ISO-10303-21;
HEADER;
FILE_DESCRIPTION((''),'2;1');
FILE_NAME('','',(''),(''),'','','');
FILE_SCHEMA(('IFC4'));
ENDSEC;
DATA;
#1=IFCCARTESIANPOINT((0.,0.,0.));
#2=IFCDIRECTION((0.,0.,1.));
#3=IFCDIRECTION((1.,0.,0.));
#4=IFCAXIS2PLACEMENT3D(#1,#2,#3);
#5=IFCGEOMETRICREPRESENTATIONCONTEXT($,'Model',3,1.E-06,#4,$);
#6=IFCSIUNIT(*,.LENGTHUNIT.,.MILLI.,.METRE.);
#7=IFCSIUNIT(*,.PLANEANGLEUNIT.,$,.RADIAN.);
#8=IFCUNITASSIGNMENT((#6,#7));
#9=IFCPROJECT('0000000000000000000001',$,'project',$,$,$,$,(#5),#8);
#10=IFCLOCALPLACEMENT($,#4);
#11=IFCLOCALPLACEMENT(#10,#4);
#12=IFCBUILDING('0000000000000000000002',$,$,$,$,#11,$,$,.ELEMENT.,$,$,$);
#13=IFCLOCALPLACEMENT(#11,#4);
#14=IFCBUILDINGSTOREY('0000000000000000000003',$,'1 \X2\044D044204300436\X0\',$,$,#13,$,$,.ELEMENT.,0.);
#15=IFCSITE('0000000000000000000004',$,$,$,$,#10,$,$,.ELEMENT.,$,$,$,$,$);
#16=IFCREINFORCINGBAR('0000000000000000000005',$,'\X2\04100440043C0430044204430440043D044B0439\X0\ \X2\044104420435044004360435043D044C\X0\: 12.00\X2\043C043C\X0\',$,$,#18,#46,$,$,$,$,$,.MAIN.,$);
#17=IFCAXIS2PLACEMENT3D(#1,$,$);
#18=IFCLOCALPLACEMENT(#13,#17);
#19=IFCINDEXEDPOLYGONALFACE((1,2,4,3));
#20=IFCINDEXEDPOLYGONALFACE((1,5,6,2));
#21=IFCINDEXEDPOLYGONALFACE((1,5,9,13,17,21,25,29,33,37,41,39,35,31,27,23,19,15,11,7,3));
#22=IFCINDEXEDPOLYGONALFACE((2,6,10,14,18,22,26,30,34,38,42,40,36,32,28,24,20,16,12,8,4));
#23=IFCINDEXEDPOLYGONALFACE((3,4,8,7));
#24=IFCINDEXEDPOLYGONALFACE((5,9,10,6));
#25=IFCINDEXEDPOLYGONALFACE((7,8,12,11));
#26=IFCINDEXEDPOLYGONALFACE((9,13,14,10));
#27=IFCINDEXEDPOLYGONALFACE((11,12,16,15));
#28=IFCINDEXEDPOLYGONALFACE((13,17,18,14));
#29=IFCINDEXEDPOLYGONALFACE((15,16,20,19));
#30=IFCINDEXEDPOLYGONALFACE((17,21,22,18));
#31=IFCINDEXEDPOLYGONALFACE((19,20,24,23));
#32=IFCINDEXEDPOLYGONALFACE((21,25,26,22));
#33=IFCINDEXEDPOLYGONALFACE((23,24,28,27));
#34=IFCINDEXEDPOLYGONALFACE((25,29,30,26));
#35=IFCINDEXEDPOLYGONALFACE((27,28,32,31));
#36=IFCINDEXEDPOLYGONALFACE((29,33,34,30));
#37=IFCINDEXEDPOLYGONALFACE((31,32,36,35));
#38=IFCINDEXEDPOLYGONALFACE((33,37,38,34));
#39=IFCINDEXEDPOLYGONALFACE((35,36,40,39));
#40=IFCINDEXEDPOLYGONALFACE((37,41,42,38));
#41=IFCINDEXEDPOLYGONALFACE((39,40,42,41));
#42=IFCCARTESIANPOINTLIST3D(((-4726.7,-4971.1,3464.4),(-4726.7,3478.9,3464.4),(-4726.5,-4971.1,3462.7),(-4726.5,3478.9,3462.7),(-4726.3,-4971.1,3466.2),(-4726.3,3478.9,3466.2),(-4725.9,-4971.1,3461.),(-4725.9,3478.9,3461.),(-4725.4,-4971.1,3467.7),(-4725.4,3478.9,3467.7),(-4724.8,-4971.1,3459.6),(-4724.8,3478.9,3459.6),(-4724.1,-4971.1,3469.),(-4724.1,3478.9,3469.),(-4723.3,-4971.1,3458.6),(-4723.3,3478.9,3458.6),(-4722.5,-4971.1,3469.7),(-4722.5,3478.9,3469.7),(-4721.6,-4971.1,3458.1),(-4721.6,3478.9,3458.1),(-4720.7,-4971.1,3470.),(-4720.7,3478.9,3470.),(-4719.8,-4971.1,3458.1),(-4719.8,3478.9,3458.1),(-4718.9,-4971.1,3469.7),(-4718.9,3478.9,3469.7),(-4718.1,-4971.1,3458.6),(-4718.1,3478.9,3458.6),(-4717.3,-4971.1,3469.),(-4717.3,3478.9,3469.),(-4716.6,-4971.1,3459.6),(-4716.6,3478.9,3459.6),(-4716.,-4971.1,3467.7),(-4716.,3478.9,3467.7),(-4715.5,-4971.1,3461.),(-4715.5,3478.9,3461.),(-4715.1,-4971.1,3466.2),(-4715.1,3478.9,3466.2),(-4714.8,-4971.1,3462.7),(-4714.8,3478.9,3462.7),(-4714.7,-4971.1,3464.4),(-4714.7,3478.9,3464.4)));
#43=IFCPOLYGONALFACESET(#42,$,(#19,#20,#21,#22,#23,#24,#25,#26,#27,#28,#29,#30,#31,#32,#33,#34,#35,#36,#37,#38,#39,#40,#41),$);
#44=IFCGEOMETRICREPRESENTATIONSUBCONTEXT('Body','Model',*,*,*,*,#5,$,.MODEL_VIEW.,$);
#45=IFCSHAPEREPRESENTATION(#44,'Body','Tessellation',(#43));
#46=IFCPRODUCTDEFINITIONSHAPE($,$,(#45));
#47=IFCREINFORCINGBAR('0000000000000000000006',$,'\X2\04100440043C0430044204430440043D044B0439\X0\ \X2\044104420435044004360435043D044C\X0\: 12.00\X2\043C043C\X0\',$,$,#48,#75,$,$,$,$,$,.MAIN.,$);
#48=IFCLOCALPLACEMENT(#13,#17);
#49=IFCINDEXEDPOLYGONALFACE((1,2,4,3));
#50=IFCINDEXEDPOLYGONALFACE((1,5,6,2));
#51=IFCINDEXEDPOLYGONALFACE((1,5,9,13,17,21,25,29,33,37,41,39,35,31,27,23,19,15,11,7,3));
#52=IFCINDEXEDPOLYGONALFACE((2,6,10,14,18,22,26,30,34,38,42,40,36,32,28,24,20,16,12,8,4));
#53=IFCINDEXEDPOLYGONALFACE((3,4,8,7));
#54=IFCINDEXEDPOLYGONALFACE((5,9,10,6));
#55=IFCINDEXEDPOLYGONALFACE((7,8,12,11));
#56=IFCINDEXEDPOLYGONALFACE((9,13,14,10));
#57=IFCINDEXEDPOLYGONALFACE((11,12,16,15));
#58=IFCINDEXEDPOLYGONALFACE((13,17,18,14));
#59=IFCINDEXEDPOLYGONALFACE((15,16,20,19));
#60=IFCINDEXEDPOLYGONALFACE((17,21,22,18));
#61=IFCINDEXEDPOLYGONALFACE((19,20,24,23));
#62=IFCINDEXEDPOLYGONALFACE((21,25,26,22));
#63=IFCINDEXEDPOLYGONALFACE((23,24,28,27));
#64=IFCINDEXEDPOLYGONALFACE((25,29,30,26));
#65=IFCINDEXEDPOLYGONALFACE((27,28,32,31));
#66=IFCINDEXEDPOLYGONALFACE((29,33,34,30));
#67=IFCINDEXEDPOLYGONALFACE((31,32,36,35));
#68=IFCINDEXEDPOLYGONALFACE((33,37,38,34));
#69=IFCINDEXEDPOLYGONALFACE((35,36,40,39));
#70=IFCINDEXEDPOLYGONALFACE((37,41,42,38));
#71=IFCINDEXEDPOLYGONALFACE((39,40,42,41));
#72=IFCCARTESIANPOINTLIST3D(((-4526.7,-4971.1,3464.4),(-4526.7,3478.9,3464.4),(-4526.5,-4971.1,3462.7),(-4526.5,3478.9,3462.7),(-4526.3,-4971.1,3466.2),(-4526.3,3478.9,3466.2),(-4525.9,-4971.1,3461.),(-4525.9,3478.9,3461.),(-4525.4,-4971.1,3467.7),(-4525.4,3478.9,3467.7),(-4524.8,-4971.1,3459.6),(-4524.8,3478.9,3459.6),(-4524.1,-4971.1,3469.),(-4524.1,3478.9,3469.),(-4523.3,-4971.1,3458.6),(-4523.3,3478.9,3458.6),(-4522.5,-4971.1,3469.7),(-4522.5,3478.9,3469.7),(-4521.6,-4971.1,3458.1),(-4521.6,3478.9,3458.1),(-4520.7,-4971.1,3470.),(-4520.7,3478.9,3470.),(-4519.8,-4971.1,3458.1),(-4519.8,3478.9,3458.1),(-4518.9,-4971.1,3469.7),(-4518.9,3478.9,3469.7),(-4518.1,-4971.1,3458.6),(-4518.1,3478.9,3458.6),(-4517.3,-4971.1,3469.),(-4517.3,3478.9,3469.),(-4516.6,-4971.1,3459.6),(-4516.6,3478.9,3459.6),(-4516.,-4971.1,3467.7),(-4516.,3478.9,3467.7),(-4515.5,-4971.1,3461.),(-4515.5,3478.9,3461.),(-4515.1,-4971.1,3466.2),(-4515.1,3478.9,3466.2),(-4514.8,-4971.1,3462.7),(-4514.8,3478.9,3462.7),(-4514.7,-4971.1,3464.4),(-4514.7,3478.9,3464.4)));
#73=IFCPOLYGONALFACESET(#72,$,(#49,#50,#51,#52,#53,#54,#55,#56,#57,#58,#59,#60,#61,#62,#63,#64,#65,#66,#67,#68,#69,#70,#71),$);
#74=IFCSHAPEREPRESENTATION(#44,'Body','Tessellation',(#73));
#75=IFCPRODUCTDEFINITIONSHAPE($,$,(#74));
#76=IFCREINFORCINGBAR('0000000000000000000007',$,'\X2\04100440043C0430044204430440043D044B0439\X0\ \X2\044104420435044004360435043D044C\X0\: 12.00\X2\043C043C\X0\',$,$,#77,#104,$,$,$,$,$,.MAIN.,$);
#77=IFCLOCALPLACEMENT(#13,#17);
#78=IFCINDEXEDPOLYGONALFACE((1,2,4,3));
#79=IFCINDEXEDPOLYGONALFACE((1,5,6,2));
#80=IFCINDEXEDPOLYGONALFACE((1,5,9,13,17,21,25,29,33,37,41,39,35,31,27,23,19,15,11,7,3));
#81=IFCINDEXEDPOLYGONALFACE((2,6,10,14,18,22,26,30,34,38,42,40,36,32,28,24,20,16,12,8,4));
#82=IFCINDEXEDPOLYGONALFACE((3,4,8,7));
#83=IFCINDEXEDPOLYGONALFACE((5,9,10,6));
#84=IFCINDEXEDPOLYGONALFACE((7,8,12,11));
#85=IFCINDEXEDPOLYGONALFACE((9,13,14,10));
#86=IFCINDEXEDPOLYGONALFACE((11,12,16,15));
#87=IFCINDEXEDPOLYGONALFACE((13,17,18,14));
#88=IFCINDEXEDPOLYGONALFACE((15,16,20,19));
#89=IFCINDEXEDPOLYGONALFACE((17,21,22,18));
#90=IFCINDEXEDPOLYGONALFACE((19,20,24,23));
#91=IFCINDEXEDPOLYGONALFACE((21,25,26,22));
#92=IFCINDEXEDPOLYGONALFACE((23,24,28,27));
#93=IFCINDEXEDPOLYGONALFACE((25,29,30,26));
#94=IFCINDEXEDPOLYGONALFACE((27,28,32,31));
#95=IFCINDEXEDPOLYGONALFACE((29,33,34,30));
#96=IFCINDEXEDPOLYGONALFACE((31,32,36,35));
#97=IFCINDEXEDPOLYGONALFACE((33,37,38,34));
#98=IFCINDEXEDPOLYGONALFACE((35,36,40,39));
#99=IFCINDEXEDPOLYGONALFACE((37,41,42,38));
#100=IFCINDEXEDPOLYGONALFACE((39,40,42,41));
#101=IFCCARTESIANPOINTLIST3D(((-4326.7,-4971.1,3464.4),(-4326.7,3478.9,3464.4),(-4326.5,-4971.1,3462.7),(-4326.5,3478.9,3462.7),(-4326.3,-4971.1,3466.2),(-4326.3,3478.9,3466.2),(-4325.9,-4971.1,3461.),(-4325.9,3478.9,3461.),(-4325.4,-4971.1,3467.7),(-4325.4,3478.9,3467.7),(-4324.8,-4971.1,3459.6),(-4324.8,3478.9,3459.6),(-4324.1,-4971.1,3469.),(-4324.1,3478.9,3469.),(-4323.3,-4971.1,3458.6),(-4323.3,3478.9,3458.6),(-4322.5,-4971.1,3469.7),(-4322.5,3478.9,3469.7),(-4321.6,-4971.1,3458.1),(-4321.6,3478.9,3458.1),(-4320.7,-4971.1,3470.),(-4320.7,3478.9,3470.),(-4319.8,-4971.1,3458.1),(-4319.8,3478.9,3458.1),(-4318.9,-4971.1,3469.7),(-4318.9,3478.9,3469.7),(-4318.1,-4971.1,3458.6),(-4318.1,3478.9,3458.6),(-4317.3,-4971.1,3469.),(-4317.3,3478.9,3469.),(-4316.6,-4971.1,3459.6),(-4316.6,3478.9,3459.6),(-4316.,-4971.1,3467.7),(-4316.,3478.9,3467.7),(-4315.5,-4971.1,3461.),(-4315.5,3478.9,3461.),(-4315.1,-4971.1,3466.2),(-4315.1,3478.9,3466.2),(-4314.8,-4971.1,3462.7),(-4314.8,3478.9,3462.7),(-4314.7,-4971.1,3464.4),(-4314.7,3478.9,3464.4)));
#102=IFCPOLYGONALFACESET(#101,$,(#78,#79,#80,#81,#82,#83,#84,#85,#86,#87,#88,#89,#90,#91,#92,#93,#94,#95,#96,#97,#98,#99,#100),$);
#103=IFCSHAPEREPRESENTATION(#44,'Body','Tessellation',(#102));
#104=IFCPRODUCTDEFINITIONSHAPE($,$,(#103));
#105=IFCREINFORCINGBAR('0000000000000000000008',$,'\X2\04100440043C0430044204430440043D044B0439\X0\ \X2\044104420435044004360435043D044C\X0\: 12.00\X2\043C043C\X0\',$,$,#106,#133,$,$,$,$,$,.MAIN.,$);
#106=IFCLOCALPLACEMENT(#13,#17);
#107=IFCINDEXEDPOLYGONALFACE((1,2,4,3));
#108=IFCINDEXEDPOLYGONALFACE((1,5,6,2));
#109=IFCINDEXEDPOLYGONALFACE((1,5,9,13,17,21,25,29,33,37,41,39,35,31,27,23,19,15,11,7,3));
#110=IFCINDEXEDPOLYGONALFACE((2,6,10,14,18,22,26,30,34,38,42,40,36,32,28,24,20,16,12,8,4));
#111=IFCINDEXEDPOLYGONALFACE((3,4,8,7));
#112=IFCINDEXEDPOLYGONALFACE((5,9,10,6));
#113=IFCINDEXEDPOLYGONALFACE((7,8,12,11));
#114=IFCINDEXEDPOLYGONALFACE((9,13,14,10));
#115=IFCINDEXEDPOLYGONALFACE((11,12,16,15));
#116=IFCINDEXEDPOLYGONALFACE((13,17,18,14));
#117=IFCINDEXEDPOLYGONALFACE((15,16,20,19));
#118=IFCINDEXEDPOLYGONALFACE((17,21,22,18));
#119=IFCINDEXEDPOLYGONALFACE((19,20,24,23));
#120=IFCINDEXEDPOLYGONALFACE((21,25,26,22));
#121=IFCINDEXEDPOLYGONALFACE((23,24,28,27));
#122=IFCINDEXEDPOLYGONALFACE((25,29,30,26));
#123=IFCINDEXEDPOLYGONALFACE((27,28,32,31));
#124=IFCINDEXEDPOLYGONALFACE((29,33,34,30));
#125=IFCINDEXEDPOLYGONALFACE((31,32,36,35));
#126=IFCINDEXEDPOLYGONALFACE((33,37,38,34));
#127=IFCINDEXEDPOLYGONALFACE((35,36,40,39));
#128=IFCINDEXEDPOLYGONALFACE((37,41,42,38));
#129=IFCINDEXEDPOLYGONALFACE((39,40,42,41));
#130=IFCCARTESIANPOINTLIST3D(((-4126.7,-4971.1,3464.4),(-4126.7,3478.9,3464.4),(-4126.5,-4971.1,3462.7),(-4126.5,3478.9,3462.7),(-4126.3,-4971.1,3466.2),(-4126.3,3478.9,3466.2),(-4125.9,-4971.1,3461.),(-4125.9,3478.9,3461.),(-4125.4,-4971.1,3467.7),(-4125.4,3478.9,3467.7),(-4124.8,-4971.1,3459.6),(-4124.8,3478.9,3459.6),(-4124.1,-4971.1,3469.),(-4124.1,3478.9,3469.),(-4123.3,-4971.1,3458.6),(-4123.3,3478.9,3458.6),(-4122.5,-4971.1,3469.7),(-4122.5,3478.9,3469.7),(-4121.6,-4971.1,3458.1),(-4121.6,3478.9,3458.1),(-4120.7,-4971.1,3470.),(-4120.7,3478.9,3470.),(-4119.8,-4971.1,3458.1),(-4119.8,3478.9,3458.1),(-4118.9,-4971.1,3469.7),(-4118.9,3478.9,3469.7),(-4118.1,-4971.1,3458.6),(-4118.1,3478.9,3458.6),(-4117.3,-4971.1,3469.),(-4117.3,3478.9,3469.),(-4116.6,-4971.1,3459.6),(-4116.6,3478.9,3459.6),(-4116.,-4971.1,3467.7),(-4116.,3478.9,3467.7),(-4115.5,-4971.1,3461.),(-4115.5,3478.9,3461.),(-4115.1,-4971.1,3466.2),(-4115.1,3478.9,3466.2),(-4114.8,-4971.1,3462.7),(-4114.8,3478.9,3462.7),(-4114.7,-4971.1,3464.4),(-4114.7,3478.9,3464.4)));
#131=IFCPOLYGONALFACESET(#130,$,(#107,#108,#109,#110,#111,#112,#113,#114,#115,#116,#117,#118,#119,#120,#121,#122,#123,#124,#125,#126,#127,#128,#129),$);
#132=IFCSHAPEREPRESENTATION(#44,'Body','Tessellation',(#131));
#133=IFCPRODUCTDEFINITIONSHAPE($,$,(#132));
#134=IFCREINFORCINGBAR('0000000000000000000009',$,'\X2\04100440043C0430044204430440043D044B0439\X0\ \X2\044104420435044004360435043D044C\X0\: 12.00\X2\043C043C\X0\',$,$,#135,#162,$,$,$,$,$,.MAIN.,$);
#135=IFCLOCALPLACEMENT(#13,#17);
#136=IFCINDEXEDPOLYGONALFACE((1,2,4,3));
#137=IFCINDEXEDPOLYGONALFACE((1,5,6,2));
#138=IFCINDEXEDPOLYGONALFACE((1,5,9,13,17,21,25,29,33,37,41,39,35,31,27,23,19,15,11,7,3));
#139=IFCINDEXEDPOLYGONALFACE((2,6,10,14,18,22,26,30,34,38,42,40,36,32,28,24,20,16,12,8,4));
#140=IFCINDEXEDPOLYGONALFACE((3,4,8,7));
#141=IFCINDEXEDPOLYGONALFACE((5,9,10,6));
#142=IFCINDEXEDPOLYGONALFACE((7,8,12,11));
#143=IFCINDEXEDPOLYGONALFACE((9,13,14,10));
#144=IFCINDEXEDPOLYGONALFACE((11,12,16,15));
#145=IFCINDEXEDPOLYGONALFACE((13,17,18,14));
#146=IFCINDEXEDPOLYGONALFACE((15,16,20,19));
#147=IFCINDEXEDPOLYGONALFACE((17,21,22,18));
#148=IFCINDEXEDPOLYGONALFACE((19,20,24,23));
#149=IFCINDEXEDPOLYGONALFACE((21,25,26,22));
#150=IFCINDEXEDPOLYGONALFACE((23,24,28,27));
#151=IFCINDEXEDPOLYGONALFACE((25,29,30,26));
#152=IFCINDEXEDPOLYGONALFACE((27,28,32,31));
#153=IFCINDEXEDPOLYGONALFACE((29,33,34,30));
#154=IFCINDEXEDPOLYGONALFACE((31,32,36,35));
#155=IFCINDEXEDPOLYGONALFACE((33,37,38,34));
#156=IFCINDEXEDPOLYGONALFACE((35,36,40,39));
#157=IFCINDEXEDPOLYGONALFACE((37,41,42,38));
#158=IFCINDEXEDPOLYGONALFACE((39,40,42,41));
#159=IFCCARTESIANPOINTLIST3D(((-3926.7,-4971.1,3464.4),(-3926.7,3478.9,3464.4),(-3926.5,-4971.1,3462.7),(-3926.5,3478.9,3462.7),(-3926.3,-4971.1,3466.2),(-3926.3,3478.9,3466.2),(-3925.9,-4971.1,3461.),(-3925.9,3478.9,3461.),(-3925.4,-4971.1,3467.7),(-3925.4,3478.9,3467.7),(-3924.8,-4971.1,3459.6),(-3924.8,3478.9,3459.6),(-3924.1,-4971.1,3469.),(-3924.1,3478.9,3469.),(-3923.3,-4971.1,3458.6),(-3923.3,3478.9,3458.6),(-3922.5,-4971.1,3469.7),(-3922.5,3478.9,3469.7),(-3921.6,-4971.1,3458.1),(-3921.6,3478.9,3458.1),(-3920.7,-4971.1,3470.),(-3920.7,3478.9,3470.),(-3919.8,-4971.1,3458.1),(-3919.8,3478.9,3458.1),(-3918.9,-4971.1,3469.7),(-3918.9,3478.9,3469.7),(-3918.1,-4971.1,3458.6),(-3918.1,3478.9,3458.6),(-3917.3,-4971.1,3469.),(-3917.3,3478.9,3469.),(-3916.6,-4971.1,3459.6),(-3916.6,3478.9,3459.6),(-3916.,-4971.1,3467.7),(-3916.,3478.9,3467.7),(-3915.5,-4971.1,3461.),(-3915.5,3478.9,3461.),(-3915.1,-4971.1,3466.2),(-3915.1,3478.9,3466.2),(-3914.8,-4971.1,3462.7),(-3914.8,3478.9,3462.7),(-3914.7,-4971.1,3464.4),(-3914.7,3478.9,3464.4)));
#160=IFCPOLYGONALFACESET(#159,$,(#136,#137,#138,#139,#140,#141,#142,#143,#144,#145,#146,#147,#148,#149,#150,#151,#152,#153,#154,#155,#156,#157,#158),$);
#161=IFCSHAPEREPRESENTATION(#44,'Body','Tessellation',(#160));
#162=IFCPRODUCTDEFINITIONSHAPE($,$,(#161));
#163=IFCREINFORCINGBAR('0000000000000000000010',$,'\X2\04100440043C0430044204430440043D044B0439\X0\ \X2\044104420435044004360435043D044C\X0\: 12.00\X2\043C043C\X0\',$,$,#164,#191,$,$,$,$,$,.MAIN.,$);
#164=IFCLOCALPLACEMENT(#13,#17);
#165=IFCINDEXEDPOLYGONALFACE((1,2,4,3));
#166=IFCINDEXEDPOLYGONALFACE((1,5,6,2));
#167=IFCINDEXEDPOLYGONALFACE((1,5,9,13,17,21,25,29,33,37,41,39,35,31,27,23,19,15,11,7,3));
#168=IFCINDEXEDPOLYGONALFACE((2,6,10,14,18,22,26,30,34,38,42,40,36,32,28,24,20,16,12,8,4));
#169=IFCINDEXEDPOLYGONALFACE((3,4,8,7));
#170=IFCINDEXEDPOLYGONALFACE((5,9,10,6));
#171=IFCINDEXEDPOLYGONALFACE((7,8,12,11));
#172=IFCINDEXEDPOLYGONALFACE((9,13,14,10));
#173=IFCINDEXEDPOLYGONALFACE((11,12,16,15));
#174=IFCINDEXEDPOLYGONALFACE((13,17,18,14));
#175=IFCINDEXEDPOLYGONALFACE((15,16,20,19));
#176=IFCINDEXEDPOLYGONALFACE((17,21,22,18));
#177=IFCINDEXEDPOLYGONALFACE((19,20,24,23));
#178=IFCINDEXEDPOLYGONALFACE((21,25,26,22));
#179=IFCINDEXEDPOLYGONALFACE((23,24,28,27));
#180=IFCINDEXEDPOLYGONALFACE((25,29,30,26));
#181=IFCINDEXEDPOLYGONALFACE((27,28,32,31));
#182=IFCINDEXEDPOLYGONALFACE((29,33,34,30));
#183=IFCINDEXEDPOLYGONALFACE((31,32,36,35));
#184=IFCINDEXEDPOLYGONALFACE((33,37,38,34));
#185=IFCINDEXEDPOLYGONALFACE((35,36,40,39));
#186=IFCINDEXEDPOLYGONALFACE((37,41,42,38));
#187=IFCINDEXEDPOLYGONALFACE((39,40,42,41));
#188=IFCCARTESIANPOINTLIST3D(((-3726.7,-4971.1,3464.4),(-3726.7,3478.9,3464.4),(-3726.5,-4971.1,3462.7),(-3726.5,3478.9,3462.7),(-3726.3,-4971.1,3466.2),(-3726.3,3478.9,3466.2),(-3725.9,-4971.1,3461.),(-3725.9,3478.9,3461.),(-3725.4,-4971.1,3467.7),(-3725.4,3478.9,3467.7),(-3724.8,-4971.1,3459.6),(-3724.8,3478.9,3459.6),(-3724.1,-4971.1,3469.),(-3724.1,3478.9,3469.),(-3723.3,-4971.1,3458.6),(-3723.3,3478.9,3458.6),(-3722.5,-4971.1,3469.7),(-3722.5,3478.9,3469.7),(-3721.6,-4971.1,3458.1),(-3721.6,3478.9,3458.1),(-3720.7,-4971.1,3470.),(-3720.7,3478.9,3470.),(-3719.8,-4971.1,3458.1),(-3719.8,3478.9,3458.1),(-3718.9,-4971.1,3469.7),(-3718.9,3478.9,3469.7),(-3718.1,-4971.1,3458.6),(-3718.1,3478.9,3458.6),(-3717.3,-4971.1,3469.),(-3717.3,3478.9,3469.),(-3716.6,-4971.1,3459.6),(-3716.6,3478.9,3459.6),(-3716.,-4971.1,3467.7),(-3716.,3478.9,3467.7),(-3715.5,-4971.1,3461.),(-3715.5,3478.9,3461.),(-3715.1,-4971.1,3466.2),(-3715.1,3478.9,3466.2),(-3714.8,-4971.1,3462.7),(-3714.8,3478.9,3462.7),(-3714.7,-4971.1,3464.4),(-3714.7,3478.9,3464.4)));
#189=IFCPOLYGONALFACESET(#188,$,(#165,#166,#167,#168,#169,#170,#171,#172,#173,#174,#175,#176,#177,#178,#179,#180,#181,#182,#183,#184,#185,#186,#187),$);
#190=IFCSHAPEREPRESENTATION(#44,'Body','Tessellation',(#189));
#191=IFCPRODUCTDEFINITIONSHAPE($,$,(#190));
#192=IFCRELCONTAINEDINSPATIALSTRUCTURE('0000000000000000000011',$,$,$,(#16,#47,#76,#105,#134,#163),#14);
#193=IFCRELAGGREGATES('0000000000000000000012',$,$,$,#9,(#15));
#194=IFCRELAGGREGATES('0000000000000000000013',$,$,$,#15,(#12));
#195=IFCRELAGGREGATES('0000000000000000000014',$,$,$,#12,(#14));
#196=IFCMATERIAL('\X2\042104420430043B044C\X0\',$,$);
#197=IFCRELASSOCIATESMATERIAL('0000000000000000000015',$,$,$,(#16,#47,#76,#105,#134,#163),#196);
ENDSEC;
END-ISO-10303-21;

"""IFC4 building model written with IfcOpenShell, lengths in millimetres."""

from ifc_helpers import new_model, entity, si_unit, origin_with_axes, place, context, subcontext, project, spatial, source, transform, mapped, material, element, save


model = new_model("IFC4")

# Units and contexts
model_context = context("Model", 3, precision=1e-06, world=origin_with_axes())
body_context = subcontext(model_context, "Body", "Model", "MODEL_VIEW")
ifc_project = project(units=[si_unit("LENGTHUNIT", "METRE", prefix="MILLI"), si_unit("PLANEANGLEUNIT", "RADIAN")], contexts=[model_context])

# Site, building, storey
site_placement = place(None, origin_with_axes())
site = spatial("IfcSite", under=ifc_project, at=site_placement, CompositionType="ELEMENT")
building_placement = place(site_placement, origin_with_axes())
building = spatial("IfcBuilding", under=site, at=building_placement, CompositionType="ELEMENT")
storey_placement = place(building_placement, origin_with_axes())
storey = spatial("IfcBuildingStorey", under=building, at=storey_placement, Name="1 этаж", CompositionType="ELEMENT", Elevation=0.0)

# Reinforcing bars
ifc_material = material(Name="Сталь")
shared_shape = source(origin_with_axes(), body_context, "Body", "AdvancedSweptSolid", [
    entity("IfcSweptDiskSolid", entity("IfcIndexedPolyCurve", entity("IfcCartesianPointList3D", [[0.0, 0.0, 0.0], [8450.0, 0.0, 0.0]]), [entity("IfcLineIndex", [1, 2])]), 6.0),
])
reinforcing_bar_1_placement = place(storey_placement, origin_with_axes())
element("IfcReinforcingBar", 1, at=reinforcing_bar_1_placement, inside=storey, material=ifc_material, Name="Арматурный стержень: 12.00мм", PredefinedType="MAIN", context=body_context, shape_type="MappedRepresentation", body=[
    mapped(shared_shape, transform((-4720.7, -4971.1, 3464.0), x_axis=(0.0, 1.0, 0.0), y_axis=(-1.0, 0.0, 0.0), z_axis=(0.0, 0.0, 1.0), scale=1.0)),
])
reinforcing_bar_2_placement = place(storey_placement, origin_with_axes())
element("IfcReinforcingBar", 2, at=reinforcing_bar_2_placement, inside=storey, material=ifc_material, Name="Арматурный стержень: 12.00мм", PredefinedType="MAIN", context=body_context, shape_type="MappedRepresentation", body=[
    mapped(shared_shape, transform((-4520.7, -4971.1, 3464.0), x_axis=(0.0, 1.0, 0.0), y_axis=(-1.0, 0.0, 0.0), z_axis=(0.0, 0.0, 1.0), scale=1.0)),
])
reinforcing_bar_3_placement = place(storey_placement, origin_with_axes())
element("IfcReinforcingBar", 3, at=reinforcing_bar_3_placement, inside=storey, material=ifc_material, Name="Арматурный стержень: 12.00мм", PredefinedType="MAIN", context=body_context, shape_type="MappedRepresentation", body=[
    mapped(shared_shape, transform((-4320.7, -4971.1, 3464.0), x_axis=(0.0, 1.0, 0.0), y_axis=(-1.0, 0.0, 0.0), z_axis=(0.0, 0.0, 1.0), scale=1.0)),
])
reinforcing_bar_4_placement = place(storey_placement, origin_with_axes())
element("IfcReinforcingBar", 4, at=reinforcing_bar_4_placement, inside=storey, material=ifc_material, Name="Арматурный стержень: 12.00мм", PredefinedType="MAIN", context=body_context, shape_type="MappedRepresentation", body=[
    mapped(shared_shape, transform((-4120.7, -4971.1, 3464.0), x_axis=(0.0, 1.0, 0.0), y_axis=(-1.0, 0.0, 0.0), z_axis=(0.0, 0.0, 1.0), scale=1.0)),
])
reinforcing_bar_5_placement = place(storey_placement, origin_with_axes())
element("IfcReinforcingBar", 5, at=reinforcing_bar_5_placement, inside=storey, material=ifc_material, Name="Арматурный стержень: 12.00мм", PredefinedType="MAIN", context=body_context, shape_type="MappedRepresentation", body=[
    mapped(shared_shape, transform((-3920.7, -4971.1, 3464.0), x_axis=(0.0, 1.0, 0.0), y_axis=(-1.0, 0.0, 0.0), z_axis=(0.0, 0.0, 1.0), scale=1.0)),
])
reinforcing_bar_6_placement = place(storey_placement, origin_with_axes())
element("IfcReinforcingBar", 6, at=reinforcing_bar_6_placement, inside=storey, material=ifc_material, Name="Арматурный стержень: 12.00мм", PredefinedType="MAIN", context=body_context, shape_type="MappedRepresentation", body=[
    mapped(shared_shape, transform((-3720.7, -4971.1, 3464.0), x_axis=(0.0, 1.0, 0.0), y_axis=(-1.0, 0.0, 0.0), z_axis=(0.0, 0.0, 1.0), scale=1.0)),
])

save(model, "model.ifc")
